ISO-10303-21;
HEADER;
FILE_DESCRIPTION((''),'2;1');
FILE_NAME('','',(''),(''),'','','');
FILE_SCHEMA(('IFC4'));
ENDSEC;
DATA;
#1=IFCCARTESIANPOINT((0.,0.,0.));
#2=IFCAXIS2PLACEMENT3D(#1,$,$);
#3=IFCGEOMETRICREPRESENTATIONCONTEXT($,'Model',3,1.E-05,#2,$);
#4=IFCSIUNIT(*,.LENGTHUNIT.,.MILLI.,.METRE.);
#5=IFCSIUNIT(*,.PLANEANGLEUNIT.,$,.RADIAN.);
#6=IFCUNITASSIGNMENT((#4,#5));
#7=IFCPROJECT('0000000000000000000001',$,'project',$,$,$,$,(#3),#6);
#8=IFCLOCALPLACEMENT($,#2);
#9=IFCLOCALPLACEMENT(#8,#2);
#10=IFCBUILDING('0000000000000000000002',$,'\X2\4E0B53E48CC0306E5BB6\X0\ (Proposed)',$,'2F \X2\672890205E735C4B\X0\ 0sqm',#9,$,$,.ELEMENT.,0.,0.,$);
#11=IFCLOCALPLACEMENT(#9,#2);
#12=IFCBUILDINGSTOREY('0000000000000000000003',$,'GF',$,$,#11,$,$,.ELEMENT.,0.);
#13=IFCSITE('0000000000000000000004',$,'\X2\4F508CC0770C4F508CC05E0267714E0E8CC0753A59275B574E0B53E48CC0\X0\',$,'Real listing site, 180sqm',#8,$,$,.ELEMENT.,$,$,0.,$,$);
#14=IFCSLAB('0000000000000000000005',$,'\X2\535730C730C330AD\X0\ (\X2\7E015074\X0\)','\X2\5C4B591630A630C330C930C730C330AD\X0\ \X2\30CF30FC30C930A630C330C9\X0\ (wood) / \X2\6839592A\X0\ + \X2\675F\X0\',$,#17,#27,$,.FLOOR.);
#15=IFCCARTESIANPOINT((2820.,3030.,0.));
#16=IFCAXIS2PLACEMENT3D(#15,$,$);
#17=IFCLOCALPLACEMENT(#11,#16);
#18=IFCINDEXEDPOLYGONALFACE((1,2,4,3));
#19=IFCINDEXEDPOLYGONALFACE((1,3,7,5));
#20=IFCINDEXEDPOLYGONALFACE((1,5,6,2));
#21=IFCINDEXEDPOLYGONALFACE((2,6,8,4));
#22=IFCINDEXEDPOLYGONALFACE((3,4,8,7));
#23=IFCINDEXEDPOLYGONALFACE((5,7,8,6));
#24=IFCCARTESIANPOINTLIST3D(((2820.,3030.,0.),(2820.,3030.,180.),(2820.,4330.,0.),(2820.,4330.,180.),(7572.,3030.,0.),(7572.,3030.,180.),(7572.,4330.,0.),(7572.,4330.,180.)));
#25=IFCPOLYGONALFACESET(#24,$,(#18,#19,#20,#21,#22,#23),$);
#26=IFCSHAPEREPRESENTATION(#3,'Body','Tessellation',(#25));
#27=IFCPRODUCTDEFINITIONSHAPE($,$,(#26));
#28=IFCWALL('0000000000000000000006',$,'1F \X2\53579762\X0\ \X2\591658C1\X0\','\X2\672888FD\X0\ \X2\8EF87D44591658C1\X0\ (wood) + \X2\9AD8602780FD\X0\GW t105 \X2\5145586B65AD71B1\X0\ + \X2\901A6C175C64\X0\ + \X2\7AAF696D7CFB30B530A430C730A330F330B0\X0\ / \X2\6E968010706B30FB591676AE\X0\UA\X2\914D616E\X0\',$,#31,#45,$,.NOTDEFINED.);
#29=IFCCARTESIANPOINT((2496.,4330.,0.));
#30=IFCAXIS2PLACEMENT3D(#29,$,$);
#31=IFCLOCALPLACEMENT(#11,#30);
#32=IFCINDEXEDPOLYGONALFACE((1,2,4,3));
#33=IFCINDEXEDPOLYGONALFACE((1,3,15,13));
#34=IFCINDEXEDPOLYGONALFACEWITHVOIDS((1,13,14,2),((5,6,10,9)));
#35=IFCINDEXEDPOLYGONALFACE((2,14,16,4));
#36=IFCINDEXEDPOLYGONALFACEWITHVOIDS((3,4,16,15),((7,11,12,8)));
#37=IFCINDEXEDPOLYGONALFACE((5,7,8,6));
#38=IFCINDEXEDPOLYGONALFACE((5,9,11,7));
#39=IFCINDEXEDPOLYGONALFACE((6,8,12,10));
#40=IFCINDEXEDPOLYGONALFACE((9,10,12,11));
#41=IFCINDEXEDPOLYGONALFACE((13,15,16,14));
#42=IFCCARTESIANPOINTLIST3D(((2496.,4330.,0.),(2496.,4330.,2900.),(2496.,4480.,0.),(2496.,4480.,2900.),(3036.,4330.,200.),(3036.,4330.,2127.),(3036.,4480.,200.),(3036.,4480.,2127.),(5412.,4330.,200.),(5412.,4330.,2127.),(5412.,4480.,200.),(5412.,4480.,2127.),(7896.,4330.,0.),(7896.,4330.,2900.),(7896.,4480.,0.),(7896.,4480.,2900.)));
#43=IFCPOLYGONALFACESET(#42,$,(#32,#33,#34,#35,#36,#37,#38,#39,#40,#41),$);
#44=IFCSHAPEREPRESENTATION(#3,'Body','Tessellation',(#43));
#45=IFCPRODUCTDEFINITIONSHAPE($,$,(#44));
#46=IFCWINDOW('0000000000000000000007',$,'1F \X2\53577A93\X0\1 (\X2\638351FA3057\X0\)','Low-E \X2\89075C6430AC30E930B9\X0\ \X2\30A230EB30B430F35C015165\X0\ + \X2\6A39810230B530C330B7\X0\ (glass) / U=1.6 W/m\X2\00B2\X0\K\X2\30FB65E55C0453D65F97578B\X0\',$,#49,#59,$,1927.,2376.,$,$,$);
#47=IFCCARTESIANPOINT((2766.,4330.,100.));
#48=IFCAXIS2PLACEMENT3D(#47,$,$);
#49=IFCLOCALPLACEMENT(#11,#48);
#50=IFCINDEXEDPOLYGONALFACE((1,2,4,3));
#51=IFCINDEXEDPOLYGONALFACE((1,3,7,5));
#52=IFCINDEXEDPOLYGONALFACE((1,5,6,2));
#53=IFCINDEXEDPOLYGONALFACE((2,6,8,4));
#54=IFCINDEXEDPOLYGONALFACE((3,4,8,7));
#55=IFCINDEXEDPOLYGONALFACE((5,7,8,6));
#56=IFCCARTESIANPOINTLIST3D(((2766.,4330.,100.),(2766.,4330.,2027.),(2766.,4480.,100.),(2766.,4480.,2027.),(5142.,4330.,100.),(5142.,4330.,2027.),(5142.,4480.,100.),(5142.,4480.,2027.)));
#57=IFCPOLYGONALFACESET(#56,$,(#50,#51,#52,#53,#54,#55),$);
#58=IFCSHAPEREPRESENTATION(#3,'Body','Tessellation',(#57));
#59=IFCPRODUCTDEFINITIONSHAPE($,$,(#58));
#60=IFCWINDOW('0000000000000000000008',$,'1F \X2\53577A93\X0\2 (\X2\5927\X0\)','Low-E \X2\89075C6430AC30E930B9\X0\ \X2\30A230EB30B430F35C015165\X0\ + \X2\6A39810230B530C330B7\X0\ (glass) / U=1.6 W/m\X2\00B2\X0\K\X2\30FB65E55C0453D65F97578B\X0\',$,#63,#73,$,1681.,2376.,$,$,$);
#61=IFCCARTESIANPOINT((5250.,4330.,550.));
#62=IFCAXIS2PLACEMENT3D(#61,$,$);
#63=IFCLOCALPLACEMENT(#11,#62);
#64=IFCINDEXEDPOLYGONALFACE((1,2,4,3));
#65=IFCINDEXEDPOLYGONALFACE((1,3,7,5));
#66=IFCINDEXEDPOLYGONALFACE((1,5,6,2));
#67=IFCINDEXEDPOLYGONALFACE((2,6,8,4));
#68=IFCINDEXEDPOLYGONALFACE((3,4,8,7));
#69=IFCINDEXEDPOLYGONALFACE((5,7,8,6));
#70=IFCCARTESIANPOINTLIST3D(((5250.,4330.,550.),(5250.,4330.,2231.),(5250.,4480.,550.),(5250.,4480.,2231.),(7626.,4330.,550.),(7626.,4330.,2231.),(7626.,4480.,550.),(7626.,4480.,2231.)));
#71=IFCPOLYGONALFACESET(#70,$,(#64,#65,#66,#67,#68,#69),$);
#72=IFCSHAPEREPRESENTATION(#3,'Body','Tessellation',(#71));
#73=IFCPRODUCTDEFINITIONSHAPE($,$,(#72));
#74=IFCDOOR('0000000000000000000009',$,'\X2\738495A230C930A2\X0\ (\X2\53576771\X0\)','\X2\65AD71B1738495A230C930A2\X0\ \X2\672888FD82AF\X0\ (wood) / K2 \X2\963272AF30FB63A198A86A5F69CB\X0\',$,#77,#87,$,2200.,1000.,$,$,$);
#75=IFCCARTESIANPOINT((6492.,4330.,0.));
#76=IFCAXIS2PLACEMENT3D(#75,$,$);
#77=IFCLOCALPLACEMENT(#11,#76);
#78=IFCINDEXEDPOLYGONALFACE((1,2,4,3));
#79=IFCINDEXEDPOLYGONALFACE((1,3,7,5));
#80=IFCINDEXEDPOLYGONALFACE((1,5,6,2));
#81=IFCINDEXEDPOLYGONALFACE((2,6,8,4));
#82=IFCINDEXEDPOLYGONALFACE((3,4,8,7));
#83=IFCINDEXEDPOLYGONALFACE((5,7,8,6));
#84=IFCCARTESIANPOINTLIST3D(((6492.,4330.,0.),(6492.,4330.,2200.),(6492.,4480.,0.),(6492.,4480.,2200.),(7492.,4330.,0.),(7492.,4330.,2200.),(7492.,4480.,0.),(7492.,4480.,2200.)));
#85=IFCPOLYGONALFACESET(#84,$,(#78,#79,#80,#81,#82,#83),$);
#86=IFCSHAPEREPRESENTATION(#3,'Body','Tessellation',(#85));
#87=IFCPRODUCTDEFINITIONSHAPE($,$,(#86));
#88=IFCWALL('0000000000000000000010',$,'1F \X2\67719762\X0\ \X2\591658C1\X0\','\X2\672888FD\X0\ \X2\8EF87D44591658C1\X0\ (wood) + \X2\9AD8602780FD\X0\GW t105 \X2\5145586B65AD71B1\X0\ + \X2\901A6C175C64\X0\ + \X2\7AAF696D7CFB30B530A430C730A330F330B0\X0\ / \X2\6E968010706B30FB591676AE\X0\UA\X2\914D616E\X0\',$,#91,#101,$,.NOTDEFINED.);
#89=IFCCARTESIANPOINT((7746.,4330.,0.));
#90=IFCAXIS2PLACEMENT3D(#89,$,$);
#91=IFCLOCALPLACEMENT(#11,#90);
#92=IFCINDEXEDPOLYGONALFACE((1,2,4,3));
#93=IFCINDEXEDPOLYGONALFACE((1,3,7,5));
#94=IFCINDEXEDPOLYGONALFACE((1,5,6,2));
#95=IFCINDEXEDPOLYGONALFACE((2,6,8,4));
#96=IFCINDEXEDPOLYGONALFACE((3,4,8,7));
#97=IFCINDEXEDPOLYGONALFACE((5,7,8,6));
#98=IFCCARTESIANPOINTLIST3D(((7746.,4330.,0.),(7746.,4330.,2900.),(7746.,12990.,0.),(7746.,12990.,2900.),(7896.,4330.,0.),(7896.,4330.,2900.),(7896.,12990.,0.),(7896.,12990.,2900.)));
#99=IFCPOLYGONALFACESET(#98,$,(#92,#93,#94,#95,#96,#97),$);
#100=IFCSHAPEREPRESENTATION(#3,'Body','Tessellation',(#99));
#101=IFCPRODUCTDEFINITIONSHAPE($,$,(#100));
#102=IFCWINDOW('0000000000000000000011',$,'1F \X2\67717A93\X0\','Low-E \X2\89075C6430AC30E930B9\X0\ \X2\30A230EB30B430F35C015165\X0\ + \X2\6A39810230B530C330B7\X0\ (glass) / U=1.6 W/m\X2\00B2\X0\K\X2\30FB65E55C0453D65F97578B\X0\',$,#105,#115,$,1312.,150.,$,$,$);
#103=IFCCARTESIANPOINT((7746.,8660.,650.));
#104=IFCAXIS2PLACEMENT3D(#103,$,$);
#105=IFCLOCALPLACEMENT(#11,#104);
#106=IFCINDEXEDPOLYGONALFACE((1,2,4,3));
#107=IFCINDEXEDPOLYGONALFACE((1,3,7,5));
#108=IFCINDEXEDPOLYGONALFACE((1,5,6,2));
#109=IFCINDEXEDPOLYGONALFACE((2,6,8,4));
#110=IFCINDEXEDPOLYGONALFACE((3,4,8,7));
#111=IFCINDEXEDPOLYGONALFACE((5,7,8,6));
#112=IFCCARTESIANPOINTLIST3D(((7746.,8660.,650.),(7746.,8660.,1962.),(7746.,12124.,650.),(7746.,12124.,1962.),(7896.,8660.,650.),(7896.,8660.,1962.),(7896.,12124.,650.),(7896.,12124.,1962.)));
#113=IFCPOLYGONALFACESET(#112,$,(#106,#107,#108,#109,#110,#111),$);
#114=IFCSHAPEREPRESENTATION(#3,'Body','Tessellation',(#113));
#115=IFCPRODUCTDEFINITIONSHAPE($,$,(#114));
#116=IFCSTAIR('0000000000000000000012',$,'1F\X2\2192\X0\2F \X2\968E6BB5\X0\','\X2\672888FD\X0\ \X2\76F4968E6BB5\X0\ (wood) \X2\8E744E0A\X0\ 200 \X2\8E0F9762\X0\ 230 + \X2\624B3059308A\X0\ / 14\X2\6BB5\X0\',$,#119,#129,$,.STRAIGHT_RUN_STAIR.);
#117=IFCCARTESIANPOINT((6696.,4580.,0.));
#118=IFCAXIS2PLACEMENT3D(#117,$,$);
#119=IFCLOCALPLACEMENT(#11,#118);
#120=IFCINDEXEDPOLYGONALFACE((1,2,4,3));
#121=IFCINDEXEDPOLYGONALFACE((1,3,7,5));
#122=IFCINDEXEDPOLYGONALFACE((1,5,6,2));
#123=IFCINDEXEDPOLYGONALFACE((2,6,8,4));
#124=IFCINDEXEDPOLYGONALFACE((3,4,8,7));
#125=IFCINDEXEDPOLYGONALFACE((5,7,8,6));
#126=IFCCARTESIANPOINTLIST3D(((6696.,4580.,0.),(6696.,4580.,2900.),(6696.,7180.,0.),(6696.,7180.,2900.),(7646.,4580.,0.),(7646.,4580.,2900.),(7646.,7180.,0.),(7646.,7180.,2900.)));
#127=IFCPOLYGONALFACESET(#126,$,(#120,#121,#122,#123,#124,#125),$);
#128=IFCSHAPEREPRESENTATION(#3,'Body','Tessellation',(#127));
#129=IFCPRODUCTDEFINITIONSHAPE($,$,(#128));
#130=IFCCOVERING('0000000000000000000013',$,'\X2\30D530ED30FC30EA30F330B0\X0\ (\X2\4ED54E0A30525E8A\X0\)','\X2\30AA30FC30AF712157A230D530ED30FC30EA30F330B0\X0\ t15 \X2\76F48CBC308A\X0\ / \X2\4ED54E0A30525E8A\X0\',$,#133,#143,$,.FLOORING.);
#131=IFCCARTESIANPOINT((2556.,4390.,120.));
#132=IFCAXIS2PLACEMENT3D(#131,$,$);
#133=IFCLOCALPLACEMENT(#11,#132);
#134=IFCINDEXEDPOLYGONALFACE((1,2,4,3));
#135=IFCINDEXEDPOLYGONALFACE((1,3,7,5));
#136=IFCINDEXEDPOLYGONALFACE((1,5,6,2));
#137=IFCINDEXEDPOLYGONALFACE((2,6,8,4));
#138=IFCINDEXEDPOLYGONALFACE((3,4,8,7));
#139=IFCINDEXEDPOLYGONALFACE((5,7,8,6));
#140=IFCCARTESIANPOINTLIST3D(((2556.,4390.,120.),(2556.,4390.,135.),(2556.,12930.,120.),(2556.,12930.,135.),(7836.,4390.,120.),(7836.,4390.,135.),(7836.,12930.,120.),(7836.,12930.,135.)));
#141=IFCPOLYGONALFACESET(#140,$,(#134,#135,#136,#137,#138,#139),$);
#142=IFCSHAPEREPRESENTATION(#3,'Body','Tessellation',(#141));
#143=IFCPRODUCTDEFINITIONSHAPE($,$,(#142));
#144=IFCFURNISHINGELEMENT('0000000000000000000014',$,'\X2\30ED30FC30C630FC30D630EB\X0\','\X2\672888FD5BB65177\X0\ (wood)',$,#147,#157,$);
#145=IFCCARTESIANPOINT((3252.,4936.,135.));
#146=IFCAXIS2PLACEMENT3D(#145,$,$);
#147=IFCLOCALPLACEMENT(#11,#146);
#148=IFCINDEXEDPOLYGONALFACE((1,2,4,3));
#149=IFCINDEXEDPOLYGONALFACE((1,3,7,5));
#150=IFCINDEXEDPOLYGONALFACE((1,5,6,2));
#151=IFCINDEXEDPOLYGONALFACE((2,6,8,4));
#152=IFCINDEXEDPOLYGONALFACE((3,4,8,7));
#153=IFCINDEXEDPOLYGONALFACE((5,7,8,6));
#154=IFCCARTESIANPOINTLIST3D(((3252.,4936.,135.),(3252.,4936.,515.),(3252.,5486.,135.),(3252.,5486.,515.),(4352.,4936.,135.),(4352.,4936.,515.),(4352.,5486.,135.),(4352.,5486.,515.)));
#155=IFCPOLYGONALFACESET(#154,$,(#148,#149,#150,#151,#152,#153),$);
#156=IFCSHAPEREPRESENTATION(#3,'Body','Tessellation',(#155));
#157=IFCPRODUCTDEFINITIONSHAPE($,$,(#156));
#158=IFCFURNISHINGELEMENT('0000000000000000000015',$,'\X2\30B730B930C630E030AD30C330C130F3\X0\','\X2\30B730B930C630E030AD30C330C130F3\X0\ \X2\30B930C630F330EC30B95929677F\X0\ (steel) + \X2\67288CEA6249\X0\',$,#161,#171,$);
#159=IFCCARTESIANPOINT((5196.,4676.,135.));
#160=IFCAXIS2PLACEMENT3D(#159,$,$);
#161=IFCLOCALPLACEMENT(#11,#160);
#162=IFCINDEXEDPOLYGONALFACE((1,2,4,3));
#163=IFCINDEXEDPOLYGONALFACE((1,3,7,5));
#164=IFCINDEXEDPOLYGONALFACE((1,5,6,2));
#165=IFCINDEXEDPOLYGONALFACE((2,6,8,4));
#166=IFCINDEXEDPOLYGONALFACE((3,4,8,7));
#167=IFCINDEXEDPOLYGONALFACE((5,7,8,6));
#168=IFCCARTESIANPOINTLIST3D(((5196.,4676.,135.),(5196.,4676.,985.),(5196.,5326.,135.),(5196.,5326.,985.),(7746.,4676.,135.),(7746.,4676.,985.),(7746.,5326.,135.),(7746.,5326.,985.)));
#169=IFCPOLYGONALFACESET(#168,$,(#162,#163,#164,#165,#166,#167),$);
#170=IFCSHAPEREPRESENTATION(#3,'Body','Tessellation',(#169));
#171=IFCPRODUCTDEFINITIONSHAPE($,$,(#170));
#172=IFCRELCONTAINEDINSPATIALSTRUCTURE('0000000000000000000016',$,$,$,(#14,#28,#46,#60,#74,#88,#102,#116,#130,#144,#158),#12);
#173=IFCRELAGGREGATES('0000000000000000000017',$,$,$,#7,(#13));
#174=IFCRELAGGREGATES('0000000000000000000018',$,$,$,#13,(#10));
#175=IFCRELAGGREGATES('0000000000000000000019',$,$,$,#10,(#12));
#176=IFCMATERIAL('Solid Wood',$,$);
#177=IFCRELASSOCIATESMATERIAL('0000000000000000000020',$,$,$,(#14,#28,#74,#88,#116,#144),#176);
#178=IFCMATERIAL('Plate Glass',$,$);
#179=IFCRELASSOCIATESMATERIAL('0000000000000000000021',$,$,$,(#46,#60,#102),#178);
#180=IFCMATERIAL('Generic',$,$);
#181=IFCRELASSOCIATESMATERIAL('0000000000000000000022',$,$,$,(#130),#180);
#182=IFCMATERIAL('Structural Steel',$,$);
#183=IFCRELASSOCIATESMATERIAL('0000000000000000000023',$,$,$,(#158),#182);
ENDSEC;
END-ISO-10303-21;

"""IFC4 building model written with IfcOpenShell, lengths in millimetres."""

from ifc_helpers import new_model, si_unit, frame, frame_2d, origin, place, context, project, spatial, rectangle, extrude, material, element, fill, save


model = new_model("IFC4")

# Units and contexts
model_context = context("Model", 3, precision=1e-05, world=origin())
ifc_project = project(units=[si_unit("LENGTHUNIT", "METRE", prefix="MILLI"), si_unit("PLANEANGLEUNIT", "RADIAN")], contexts=[model_context])

# Site, building, storey
site_placement = place(None, origin())
site = spatial("IfcSite", under=ifc_project, at=site_placement, Name="佐賀県佐賀市東与賀町大字下古賀", ObjectType="Real listing site, 180sqm", CompositionType="ELEMENT", RefElevation=0.0)
building_placement = place(site_placement, origin())
building = spatial("IfcBuilding", under=site, at=building_placement, Name="下古賀の家 (Proposed)", ObjectType="2F 木造平屋 0sqm", CompositionType="ELEMENT", ElevationOfRefHeight=0.0, ElevationOfTerrain=0.0)
storey_placement = place(building_placement, origin())
storey = spatial("IfcBuildingStorey", under=building, at=storey_placement, Name="GF", CompositionType="ELEMENT", Elevation=0.0)

# Slab
ifc_material_1 = material(Name="Solid Wood")
slab_1_placement = place(storey_placement, frame((2820.0, 3030.0, 0.0)))
element("IfcSlab", 1, at=slab_1_placement, inside=storey, material=ifc_material_1, Name="南デッキ (縁側)", Description="屋外ウッドデッキ ハードウッド (wood) / 根太 + 束", PredefinedType="FLOOR", context=model_context, shape_type="SweptSolid", body=[
    extrude(rectangle(XDim=4752.0, YDim=1300.0, at=frame_2d((2376.0, 650.0))), frame((2820.0, 3030.0, 0.0)), (0.0, 0.0, 1.0), 180.0),
])

# Wall, openings, windows, door
wall_1_placement = place(storey_placement, frame((2496.0, 4330.0, 0.0)))
wall_1 = element("IfcWall", 2, at=wall_1_placement, inside=storey, material=ifc_material_1, Name="1F 南面 外壁", Description="木製 軸組外壁 (wood) + 高性能GW t105 充填断熱 + 通気層 + 窯業系サイディング / 準耐火・外皮UA配慮", PredefinedType="NOTDEFINED", context=model_context, shape_type="SweptSolid", body=[
    extrude(rectangle(XDim=5400.0, YDim=150.0, at=frame_2d((2700.0, 75.0))), frame((2496.0, 4330.0, 0.0)), (0.0, 0.0, 1.0), 2900.0),
])
opening_1_placement = place(storey_placement, frame((2766.0, 4330.0, 100.0)))
opening_1 = element("IfcOpeningElement", 3, at=opening_1_placement, cuts=wall_1, PredefinedType="NOTDEFINED", context=model_context, shape_type="SweptSolid", body=[
    extrude(rectangle(XDim=2376.0, YDim=150.0, at=frame_2d((1188.0, 75.0))), frame((2766.0, 4330.0, 100.0)), (0.0, 0.0, 1.0), 1927.0),
])
opening_2_placement = place(storey_placement, frame((5250.0, 4330.0, 550.0)))
opening_2 = element("IfcOpeningElement", 4, at=opening_2_placement, cuts=wall_1, PredefinedType="NOTDEFINED", context=model_context, shape_type="SweptSolid", body=[
    extrude(rectangle(XDim=2376.0, YDim=150.0, at=frame_2d((1188.0, 75.0))), frame((5250.0, 4330.0, 550.0)), (0.0, 0.0, 1.0), 1681.0),
])
opening_3_placement = place(storey_placement, frame((6492.0, 4330.0, 0.0)))
opening_3 = element("IfcOpeningElement", 5, at=opening_3_placement, cuts=wall_1, PredefinedType="NOTDEFINED", context=model_context, shape_type="SweptSolid", body=[
    extrude(rectangle(XDim=1000.0, YDim=150.0, at=frame_2d((500.0, 75.0))), frame((6492.0, 4330.0, 0.0)), (0.0, 0.0, 1.0), 2200.0),
])
ifc_material_2 = material(Name="Plate Glass")
window_1_placement = place(storey_placement, frame((2766.0, 4330.0, 100.0)))
window_1 = element("IfcWindow", 6, at=window_1_placement, inside=storey, material=ifc_material_2, Name="1F 南窓1 (掃出し)", Description="Low-E 複層ガラス アルゴン封入 + 樹脂サッシ (glass) / U=1.6 W/m²K・日射取得型", OverallHeight=1927.0, OverallWidth=2376.0, context=model_context, shape_type="SweptSolid", body=[
    extrude(rectangle(XDim=2376.0, YDim=150.0, at=frame_2d((1188.0, 75.0))), frame((2766.0, 4330.0, 100.0)), (0.0, 0.0, 1.0), 1927.0),
])
fill(opening_1, window_1)
window_2_placement = place(storey_placement, frame((5250.0, 4330.0, 550.0)))
window_2 = element("IfcWindow", 7, at=window_2_placement, inside=storey, material=ifc_material_2, Name="1F 南窓2 (大)", Description="Low-E 複層ガラス アルゴン封入 + 樹脂サッシ (glass) / U=1.6 W/m²K・日射取得型", OverallHeight=1681.0, OverallWidth=2376.0, context=model_context, shape_type="SweptSolid", body=[
    extrude(rectangle(XDim=2376.0, YDim=150.0, at=frame_2d((1188.0, 75.0))), frame((5250.0, 4330.0, 550.0)), (0.0, 0.0, 1.0), 1681.0),
])
fill(opening_2, window_2)
door_placement = place(storey_placement, frame((6492.0, 4330.0, 0.0)))
door = element("IfcDoor", 8, at=door_placement, inside=storey, material=ifc_material_1, Name="玄関ドア (南東)", Description="断熱玄関ドア 木製芯 (wood) / K2 防犯・採風機構", OverallHeight=2200.0, OverallWidth=1000.0, context=model_context, shape_type="SweptSolid", body=[
    extrude(rectangle(XDim=1000.0, YDim=150.0, at=frame_2d((500.0, 75.0))), frame((6492.0, 4330.0, 0.0)), (0.0, 0.0, 1.0), 2200.0),
])
fill(opening_3, door)

# Wall, opening, window
wall_2_placement = place(storey_placement, frame((7746.0, 4330.0, 0.0)))
wall_2 = element("IfcWall", 9, at=wall_2_placement, inside=storey, material=ifc_material_1, Name="1F 東面 外壁", Description="木製 軸組外壁 (wood) + 高性能GW t105 充填断熱 + 通気層 + 窯業系サイディング / 準耐火・外皮UA配慮", PredefinedType="NOTDEFINED", context=model_context, shape_type="SweptSolid", body=[
    extrude(rectangle(XDim=150.0, YDim=8660.0, at=frame_2d((75.0, 4330.0))), frame((7746.0, 4330.0, 0.0)), (0.0, 0.0, 1.0), 2900.0),
])
opening_4_placement = place(storey_placement, frame((7746.0, 8660.0, 650.0)))
opening_4 = element("IfcOpeningElement", 10, at=opening_4_placement, cuts=wall_2, PredefinedType="NOTDEFINED", context=model_context, shape_type="SweptSolid", body=[
    extrude(rectangle(XDim=150.0, YDim=3464.0, at=frame_2d((75.0, 1732.0))), frame((7746.0, 8660.0, 650.0)), (0.0, 0.0, 1.0), 1312.0),
])
window_3_placement = place(storey_placement, frame((7746.0, 8660.0, 650.0)))
window_3 = element("IfcWindow", 11, at=window_3_placement, inside=storey, material=ifc_material_2, Name="1F 東窓", Description="Low-E 複層ガラス アルゴン封入 + 樹脂サッシ (glass) / U=1.6 W/m²K・日射取得型", OverallHeight=1312.0, OverallWidth=150.0, context=model_context, shape_type="SweptSolid", body=[
    extrude(rectangle(XDim=150.0, YDim=3464.0, at=frame_2d((75.0, 1732.0))), frame((7746.0, 8660.0, 650.0)), (0.0, 0.0, 1.0), 1312.0),
])
fill(opening_4, window_3)

# Stair
stair_placement = place(storey_placement, frame((6696.0, 4580.0, 0.0)))
element("IfcStair", 12, at=stair_placement, inside=storey, material=ifc_material_1, Name="1F→2F 階段", Description="木製 直階段 (wood) 蹴上 200 踏面 230 + 手すり / 14段", PredefinedType="STRAIGHT_RUN_STAIR", context=model_context, shape_type="SweptSolid", body=[
    extrude(rectangle(XDim=950.0, YDim=2600.0, at=frame_2d((475.0, 1300.0))), frame((6696.0, 4580.0, 0.0)), (0.0, 0.0, 1.0), 2900.0),
])

# Covering
ifc_material_3 = material(Name="Generic")
covering_placement = place(storey_placement, frame((2556.0, 4390.0, 120.0)))
element("IfcCovering", 13, at=covering_placement, inside=storey, material=ifc_material_3, Name="フローリング (仕上げ床)", Description="オーク無垢フローリング t15 直貼り / 仕上げ床", PredefinedType="FLOORING", context=model_context, shape_type="SweptSolid", body=[
    extrude(rectangle(XDim=5280.0, YDim=8540.0, at=frame_2d((2640.0, 4270.0))), frame((2556.0, 4390.0, 120.0)), (0.0, 0.0, 1.0), 15.0),
])

# Furnishing elements
furnishing_1_placement = place(storey_placement, frame((3252.0, 4936.0, 135.0)))
element("IfcFurnishingElement", 14, at=furnishing_1_placement, inside=storey, material=ifc_material_1, Name="ローテーブル", Description="木製家具 (wood)", context=model_context, shape_type="SweptSolid", body=[
    extrude(rectangle(XDim=1100.0, YDim=550.0, at=frame_2d((550.0, 275.0))), frame((3252.0, 4936.0, 135.0)), (0.0, 0.0, 1.0), 380.0),
])
ifc_material_4 = material(Name="Structural Steel")
furnishing_2_placement = place(storey_placement, frame((5196.0, 4676.0, 135.0)))
element("IfcFurnishingElement", 15, at=furnishing_2_placement, inside=storey, material=ifc_material_4, Name="システムキッチン", Description="システムキッチン ステンレス天板 (steel) + 木質扉", context=model_context, shape_type="SweptSolid", body=[
    extrude(rectangle(XDim=2550.0, YDim=650.0, at=frame_2d((1275.0, 325.0))), frame((5196.0, 4676.0, 135.0)), (0.0, 0.0, 1.0), 850.0),
])

save(model, "model.ifc")
